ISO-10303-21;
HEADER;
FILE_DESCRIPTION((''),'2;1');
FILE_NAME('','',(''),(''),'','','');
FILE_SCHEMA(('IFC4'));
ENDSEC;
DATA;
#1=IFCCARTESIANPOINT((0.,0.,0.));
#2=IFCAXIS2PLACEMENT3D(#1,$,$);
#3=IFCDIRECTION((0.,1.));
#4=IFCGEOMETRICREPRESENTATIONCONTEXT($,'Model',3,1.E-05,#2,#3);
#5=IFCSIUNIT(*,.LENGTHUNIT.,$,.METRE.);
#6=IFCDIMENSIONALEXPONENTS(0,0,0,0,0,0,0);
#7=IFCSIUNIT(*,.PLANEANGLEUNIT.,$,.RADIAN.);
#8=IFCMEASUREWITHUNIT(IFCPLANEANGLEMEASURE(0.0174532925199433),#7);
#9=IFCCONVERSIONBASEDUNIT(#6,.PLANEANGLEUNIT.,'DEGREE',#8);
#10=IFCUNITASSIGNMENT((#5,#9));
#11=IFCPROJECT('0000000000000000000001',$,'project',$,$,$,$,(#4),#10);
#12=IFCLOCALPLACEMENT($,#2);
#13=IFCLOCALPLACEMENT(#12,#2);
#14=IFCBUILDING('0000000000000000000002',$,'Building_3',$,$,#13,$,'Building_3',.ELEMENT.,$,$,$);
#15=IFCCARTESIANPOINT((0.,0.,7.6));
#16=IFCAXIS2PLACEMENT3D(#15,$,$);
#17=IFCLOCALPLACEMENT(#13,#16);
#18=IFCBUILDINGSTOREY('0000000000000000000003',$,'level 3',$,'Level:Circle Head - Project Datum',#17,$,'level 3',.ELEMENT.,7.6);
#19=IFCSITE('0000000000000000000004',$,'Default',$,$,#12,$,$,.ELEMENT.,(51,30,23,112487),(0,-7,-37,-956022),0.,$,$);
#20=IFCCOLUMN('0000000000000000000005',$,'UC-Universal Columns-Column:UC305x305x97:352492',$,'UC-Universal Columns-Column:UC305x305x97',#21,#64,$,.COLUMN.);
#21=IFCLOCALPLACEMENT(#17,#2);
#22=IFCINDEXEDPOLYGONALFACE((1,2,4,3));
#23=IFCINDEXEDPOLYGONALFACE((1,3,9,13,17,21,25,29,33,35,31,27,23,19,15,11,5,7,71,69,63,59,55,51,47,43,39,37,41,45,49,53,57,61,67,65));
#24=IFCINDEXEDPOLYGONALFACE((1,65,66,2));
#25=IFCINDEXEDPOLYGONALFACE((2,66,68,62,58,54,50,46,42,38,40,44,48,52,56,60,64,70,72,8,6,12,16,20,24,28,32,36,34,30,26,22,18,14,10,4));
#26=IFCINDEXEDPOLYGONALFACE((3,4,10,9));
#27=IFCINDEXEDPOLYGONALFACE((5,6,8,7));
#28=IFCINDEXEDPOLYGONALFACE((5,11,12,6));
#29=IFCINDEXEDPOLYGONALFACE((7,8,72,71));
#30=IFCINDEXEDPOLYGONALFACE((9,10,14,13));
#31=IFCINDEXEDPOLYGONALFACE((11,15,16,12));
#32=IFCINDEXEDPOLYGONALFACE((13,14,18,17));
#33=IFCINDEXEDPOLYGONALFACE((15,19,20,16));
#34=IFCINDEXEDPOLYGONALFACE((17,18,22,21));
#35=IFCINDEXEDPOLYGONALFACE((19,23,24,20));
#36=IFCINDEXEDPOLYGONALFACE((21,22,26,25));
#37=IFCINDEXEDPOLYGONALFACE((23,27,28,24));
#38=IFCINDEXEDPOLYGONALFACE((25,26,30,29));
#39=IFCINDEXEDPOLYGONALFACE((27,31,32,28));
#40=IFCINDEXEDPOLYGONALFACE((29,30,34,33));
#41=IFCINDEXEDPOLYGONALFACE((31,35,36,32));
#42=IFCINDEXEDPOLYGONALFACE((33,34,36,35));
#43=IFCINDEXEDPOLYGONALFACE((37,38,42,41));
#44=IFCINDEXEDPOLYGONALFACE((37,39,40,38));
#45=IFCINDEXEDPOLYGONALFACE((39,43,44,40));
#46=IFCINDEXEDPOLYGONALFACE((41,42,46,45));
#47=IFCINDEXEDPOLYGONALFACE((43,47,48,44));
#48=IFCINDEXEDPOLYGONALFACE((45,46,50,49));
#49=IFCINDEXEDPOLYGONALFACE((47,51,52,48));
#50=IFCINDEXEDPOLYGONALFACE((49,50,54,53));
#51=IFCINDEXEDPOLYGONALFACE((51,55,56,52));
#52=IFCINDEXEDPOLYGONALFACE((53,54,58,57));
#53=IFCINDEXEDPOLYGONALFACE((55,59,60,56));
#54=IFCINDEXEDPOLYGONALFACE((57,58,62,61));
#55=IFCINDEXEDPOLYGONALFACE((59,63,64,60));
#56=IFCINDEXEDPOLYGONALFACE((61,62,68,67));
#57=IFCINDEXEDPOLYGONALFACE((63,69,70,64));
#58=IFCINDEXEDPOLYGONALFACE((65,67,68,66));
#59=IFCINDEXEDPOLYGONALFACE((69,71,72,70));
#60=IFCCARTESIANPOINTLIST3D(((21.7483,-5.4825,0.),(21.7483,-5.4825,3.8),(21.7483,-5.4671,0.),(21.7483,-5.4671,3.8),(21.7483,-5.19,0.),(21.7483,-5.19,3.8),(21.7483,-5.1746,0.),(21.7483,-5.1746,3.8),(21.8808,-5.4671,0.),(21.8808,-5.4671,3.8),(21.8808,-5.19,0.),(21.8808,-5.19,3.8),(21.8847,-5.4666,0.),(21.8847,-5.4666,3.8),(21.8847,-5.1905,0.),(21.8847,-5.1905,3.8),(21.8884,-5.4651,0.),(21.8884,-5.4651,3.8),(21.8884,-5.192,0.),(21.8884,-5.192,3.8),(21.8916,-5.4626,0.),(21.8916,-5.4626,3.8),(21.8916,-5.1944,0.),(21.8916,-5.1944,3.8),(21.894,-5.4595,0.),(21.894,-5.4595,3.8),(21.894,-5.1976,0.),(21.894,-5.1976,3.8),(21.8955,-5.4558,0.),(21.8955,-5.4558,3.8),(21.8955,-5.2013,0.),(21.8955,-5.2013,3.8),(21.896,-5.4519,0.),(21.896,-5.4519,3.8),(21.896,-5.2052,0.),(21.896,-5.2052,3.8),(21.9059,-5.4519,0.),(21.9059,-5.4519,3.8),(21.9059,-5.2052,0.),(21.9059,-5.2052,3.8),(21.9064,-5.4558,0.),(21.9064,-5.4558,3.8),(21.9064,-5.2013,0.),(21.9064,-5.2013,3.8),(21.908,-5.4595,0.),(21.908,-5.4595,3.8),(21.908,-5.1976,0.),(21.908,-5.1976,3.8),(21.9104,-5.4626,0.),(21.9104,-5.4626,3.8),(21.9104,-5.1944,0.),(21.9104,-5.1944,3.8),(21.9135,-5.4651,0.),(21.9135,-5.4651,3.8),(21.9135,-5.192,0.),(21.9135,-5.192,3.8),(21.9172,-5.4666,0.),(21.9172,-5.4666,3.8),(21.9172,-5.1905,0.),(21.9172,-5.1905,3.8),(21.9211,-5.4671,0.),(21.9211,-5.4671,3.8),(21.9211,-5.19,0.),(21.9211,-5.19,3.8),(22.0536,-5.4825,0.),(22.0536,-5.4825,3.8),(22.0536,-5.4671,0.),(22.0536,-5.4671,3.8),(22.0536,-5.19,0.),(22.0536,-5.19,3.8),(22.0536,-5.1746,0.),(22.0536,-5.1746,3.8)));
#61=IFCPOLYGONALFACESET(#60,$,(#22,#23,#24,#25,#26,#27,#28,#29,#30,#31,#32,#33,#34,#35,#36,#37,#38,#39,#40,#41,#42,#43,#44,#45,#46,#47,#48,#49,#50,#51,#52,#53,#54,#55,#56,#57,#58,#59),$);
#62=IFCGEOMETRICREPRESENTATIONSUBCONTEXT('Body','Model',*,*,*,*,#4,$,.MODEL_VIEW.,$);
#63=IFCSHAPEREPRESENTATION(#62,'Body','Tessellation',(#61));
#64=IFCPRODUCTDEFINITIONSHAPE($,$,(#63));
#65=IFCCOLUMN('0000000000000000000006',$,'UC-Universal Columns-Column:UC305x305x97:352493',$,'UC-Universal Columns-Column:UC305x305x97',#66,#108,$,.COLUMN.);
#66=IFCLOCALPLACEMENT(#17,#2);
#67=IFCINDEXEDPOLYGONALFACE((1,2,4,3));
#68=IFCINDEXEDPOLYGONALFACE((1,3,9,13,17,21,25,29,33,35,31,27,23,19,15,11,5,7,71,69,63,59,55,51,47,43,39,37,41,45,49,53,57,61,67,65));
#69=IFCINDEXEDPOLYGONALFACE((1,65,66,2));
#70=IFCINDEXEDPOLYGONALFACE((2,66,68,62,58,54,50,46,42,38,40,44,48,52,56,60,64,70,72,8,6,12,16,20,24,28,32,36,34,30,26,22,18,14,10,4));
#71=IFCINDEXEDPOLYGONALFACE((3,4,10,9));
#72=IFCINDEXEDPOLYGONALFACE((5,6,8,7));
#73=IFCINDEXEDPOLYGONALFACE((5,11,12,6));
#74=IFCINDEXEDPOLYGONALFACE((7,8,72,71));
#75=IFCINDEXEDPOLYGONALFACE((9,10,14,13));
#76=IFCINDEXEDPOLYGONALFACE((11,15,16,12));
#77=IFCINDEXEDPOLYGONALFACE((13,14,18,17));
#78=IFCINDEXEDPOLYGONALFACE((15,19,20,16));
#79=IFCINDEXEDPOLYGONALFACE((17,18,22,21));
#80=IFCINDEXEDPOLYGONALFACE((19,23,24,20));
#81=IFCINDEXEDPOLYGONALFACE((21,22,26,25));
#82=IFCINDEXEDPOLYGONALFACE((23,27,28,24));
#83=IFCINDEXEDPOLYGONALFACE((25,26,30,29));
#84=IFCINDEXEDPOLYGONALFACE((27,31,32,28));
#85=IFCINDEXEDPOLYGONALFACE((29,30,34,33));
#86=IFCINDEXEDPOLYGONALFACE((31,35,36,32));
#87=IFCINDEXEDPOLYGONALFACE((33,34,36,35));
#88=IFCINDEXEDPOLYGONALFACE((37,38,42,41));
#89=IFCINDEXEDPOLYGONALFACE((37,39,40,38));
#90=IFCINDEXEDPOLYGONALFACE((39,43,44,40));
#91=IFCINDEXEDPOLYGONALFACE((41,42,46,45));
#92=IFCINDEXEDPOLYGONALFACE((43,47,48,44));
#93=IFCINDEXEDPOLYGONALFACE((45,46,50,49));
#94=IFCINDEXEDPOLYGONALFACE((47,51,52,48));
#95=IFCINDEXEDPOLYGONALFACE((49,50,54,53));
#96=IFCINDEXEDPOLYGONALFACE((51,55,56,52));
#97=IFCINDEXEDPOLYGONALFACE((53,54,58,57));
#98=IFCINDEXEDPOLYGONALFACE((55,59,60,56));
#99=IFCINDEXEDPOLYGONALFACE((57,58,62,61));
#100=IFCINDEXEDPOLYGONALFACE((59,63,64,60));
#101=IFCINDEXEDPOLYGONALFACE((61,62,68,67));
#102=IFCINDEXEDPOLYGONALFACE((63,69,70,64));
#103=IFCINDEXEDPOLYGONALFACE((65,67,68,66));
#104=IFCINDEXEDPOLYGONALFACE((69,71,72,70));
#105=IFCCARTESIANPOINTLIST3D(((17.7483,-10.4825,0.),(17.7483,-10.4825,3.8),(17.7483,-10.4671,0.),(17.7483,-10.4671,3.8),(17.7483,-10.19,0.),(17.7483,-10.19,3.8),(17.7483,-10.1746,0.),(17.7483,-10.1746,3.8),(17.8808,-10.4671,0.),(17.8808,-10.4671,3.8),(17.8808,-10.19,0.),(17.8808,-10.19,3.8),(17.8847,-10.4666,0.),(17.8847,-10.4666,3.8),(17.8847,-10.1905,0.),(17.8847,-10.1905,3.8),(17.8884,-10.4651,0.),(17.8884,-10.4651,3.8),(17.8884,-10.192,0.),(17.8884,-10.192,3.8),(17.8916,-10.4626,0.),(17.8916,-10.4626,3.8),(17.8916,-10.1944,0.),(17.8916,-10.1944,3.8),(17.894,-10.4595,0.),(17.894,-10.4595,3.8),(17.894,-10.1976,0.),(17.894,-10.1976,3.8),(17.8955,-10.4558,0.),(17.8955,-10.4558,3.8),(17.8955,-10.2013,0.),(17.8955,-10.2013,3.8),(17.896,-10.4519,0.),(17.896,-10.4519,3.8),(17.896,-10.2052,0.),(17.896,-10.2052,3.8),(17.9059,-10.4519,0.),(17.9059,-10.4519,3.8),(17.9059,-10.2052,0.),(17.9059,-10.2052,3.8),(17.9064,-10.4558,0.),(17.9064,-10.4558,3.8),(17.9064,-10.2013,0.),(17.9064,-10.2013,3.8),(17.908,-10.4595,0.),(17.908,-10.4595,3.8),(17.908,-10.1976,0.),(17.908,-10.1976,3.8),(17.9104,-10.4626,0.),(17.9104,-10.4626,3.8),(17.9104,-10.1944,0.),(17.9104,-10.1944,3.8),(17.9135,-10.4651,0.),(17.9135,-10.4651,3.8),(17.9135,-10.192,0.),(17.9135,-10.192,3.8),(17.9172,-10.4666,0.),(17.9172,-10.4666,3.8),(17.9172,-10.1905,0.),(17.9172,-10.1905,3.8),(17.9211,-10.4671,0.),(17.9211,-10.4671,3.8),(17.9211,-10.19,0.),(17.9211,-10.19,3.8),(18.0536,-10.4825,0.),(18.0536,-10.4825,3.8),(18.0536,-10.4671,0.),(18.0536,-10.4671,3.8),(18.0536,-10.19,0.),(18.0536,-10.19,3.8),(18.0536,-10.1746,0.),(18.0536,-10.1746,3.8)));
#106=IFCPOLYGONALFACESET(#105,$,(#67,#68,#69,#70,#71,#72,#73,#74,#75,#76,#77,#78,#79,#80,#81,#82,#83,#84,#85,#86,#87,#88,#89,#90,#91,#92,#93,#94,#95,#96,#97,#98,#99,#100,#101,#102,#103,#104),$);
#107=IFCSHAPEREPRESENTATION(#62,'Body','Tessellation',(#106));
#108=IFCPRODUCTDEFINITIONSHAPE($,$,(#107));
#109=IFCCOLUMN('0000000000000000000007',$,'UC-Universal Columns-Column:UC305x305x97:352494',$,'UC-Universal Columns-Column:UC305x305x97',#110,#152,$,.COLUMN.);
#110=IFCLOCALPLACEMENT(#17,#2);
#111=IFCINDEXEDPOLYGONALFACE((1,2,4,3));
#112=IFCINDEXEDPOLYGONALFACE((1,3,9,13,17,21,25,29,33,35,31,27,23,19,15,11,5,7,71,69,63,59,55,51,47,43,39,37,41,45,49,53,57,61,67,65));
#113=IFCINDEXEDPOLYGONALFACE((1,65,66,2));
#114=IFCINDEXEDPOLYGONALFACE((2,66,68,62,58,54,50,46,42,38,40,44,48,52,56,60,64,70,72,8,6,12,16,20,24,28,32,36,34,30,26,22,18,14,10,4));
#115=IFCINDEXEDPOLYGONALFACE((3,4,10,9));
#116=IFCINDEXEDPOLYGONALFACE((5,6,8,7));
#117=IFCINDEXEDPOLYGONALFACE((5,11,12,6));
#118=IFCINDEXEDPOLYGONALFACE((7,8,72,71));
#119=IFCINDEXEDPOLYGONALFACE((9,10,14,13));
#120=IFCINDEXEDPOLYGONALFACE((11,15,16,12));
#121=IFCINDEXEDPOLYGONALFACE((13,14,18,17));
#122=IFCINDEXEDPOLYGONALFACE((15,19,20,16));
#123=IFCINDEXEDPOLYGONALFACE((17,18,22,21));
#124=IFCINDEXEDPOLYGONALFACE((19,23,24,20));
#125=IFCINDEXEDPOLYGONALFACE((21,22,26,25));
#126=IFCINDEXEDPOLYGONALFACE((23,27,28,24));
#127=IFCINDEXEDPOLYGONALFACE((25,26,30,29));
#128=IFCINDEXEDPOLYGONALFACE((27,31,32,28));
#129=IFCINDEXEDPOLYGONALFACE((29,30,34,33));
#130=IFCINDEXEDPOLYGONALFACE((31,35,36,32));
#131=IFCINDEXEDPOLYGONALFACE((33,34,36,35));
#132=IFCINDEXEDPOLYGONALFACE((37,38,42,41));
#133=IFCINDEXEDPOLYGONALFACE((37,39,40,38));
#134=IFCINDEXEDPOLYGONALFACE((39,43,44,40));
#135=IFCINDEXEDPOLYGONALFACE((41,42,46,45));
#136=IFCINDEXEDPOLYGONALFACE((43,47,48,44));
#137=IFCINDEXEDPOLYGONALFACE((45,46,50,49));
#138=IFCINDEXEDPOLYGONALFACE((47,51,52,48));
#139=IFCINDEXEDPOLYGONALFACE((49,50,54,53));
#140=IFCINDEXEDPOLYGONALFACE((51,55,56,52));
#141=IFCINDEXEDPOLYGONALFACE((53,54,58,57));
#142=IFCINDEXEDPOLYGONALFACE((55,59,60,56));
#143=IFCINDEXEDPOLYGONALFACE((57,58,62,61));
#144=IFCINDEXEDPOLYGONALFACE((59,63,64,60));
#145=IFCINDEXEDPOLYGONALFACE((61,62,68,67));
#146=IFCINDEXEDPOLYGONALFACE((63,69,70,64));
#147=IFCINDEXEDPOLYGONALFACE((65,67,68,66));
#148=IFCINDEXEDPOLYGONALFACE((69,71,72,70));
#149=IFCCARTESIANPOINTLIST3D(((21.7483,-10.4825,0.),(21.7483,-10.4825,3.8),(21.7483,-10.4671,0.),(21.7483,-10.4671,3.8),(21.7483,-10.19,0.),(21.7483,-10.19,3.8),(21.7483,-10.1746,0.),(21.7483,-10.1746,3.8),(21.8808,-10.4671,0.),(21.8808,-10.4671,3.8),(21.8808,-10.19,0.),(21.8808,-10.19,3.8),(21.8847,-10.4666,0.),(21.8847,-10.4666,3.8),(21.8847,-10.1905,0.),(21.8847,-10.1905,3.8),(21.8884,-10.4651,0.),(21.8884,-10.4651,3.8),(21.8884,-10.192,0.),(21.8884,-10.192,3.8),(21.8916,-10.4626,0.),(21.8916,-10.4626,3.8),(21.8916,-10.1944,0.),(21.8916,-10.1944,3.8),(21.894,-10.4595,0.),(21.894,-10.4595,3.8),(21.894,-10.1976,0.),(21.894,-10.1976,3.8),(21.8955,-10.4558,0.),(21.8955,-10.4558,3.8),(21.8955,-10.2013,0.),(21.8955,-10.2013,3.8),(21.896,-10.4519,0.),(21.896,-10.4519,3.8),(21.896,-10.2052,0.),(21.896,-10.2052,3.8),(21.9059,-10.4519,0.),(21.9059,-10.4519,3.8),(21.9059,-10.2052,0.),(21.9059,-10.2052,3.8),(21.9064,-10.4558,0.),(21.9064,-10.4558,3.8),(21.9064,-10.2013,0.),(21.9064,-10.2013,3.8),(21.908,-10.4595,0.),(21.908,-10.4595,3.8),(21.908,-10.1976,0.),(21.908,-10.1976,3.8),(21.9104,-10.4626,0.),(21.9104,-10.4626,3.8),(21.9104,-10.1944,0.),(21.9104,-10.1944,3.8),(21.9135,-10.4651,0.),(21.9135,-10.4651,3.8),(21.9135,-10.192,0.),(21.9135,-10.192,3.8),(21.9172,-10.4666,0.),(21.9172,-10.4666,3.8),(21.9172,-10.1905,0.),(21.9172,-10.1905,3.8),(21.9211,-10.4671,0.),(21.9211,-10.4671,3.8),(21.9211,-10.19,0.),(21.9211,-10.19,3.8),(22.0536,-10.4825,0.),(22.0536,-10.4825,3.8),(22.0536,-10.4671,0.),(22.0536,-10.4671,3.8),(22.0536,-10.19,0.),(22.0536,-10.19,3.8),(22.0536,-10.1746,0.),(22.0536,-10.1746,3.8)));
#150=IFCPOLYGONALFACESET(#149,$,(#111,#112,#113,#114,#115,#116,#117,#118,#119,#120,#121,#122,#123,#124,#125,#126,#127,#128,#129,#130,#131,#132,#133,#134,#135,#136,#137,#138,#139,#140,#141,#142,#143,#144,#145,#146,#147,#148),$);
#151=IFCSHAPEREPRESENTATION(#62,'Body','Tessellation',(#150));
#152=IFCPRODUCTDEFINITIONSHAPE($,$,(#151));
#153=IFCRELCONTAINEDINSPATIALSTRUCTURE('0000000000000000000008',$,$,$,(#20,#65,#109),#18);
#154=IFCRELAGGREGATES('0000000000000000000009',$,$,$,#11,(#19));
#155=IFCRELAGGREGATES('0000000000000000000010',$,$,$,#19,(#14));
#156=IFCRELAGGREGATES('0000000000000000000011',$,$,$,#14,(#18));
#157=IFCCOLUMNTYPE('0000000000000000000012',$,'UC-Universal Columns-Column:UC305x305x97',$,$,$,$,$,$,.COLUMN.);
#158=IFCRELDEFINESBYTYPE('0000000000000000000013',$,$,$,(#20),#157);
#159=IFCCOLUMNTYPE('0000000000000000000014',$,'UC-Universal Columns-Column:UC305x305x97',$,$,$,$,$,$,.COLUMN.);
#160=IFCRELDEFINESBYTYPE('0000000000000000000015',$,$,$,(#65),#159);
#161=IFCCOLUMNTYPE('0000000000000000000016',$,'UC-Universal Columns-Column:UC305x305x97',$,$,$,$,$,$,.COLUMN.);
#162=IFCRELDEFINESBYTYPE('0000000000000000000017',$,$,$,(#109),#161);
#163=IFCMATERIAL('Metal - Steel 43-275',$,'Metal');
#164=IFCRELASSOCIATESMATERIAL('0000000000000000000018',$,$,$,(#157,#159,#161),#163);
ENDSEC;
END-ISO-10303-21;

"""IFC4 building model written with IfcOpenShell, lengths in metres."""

from ifc_helpers import new_model, entity, si_unit, converted_unit, direction, frame, frame_2d, origin, place, context, subcontext, project, spatial, i_section, extrude, source, transform, mapped, material, material_profile, profile_set, type_object, type_shapes, element, save


model = new_model("IFC4")

# Units and contexts
model_context = context("Model", 3, precision=1e-05, world=origin(), true_north=direction((0.0, 1.0)))
body_context = subcontext(model_context, "Body", "Model", "MODEL_VIEW")
ifc_project = project(units=[si_unit("LENGTHUNIT", "METRE"), converted_unit("PLANEANGLEUNIT", "DEGREE", entity("IfcPlaneAngleMeasure", 0.0174532925199433), si_unit("PLANEANGLEUNIT", "RADIAN"), dimensions=[0, 0, 0, 0, 0, 0, 0])], contexts=[model_context])

# Site, building, storey
site_placement = place(None, origin())
site = spatial("IfcSite", under=ifc_project, at=site_placement, Name="Default", CompositionType="ELEMENT", RefLatitude=(51, 30, 23, 112487), RefLongitude=(0, -7, -37, -956022), RefElevation=0.0)
building_placement = place(site_placement, origin())
building = spatial("IfcBuilding", under=site, at=building_placement, Name="Building_3", LongName="Building_3", CompositionType="ELEMENT")
storey_placement = place(building_placement, frame((0.0, 0.0, 7.6)))
storey = spatial("IfcBuildingStorey", under=building, at=storey_placement, Name="level 3", ObjectType="Level:Circle Head - Project Datum", LongName="level 3", CompositionType="ELEMENT", Elevation=7.6)

# Columns
ifc_material_1 = material(Name="Metal - Steel 43-275", Category="Metal")
ifc_material_profile_1 = material_profile(ifc_material_1, i_section(OverallWidth=0.3053, OverallDepth=0.3079, WebThickness=0.0099, FlangeThickness=0.0154, FilletRadius=0.0152, at=frame_2d((0.0, 0.0), x_axis=(1.0, 0.0))), Name="UC305x305x97")
ifc_profile_set_1 = profile_set([ifc_material_profile_1], Name="UC305x305x97")
column_type_1 = type_object("IfcColumnType", Name="UC-Universal Columns-Column:UC305x305x97", PredefinedType="COLUMN", material=ifc_profile_set_1)
shared_shape_1 = source(origin(), body_context, "Body", "SweptSolid", [
    extrude(i_section(OverallWidth=0.3053, OverallDepth=0.3079, WebThickness=0.0099, FlangeThickness=0.0154, FilletRadius=0.0152, at=frame_2d((0.0, 0.0), x_axis=(1.0, 0.0))), frame((21.901, -5.3285, 7.6), z_axis=(0.0, 0.0, 1.0), x_axis=(-1.0, 0.0, 0.0)), (0.0, 0.0, 1.0), 3.8),
])
type_shapes(column_type_1, [shared_shape_1])
column_1_placement = place(storey_placement, frame((0.0, 0.0, -7.6)))
element("IfcColumn", 1, at=column_1_placement, inside=storey, type_object=column_type_1, Name="UC-Universal Columns-Column:UC305x305x97:352492", ObjectType="UC-Universal Columns-Column:UC305x305x97", PredefinedType="COLUMN", context=body_context, shape_type="MappedRepresentation", body=[
    mapped(shared_shape_1, transform((0.0, 0.0, 0.0), scale=1.0)),
])
column_type_2 = type_object("IfcColumnType", Name="UC-Universal Columns-Column:UC305x305x97", PredefinedType="COLUMN", material=ifc_profile_set_1)
shared_shape_2 = source(origin(), body_context, "Body", "SweptSolid", [
    extrude(i_section(OverallWidth=0.3053, OverallDepth=0.3079, WebThickness=0.0099, FlangeThickness=0.0154, FilletRadius=0.0152, at=frame_2d((0.0, 0.0), x_axis=(1.0, 0.0))), frame((17.901, -10.3285, 7.6), z_axis=(0.0, 0.0, 1.0), x_axis=(-1.0, 0.0, 0.0)), (0.0, 0.0, 1.0), 3.8),
])
type_shapes(column_type_2, [shared_shape_2])
column_2_placement = place(storey_placement, frame((0.0, 0.0, -7.6)))
element("IfcColumn", 2, at=column_2_placement, inside=storey, type_object=column_type_2, Name="UC-Universal Columns-Column:UC305x305x97:352493", ObjectType="UC-Universal Columns-Column:UC305x305x97", PredefinedType="COLUMN", context=body_context, shape_type="MappedRepresentation", body=[
    mapped(shared_shape_2, transform((0.0, 0.0, 0.0), scale=1.0)),
])
column_type_3 = type_object("IfcColumnType", Name="UC-Universal Columns-Column:UC305x305x97", PredefinedType="COLUMN", material=ifc_profile_set_1)
shared_shape_3 = source(origin(), body_context, "Body", "SweptSolid", [
    extrude(i_section(OverallWidth=0.3053, OverallDepth=0.3079, WebThickness=0.0099, FlangeThickness=0.0154, FilletRadius=0.0152, at=frame_2d((0.0, 0.0), x_axis=(1.0, 0.0))), frame((21.901, -10.3285, 7.6), z_axis=(0.0, 0.0, 1.0), x_axis=(-1.0, 0.0, 0.0)), (0.0, 0.0, 1.0), 3.8),
])
type_shapes(column_type_3, [shared_shape_3])
column_3_placement = place(storey_placement, frame((0.0, 0.0, -7.6)))
element("IfcColumn", 3, at=column_3_placement, inside=storey, type_object=column_type_3, Name="UC-Universal Columns-Column:UC305x305x97:352494", ObjectType="UC-Universal Columns-Column:UC305x305x97", PredefinedType="COLUMN", context=body_context, shape_type="MappedRepresentation", body=[
    mapped(shared_shape_3, transform((0.0, 0.0, 0.0), scale=1.0)),
])

save(model, "model.ifc")
